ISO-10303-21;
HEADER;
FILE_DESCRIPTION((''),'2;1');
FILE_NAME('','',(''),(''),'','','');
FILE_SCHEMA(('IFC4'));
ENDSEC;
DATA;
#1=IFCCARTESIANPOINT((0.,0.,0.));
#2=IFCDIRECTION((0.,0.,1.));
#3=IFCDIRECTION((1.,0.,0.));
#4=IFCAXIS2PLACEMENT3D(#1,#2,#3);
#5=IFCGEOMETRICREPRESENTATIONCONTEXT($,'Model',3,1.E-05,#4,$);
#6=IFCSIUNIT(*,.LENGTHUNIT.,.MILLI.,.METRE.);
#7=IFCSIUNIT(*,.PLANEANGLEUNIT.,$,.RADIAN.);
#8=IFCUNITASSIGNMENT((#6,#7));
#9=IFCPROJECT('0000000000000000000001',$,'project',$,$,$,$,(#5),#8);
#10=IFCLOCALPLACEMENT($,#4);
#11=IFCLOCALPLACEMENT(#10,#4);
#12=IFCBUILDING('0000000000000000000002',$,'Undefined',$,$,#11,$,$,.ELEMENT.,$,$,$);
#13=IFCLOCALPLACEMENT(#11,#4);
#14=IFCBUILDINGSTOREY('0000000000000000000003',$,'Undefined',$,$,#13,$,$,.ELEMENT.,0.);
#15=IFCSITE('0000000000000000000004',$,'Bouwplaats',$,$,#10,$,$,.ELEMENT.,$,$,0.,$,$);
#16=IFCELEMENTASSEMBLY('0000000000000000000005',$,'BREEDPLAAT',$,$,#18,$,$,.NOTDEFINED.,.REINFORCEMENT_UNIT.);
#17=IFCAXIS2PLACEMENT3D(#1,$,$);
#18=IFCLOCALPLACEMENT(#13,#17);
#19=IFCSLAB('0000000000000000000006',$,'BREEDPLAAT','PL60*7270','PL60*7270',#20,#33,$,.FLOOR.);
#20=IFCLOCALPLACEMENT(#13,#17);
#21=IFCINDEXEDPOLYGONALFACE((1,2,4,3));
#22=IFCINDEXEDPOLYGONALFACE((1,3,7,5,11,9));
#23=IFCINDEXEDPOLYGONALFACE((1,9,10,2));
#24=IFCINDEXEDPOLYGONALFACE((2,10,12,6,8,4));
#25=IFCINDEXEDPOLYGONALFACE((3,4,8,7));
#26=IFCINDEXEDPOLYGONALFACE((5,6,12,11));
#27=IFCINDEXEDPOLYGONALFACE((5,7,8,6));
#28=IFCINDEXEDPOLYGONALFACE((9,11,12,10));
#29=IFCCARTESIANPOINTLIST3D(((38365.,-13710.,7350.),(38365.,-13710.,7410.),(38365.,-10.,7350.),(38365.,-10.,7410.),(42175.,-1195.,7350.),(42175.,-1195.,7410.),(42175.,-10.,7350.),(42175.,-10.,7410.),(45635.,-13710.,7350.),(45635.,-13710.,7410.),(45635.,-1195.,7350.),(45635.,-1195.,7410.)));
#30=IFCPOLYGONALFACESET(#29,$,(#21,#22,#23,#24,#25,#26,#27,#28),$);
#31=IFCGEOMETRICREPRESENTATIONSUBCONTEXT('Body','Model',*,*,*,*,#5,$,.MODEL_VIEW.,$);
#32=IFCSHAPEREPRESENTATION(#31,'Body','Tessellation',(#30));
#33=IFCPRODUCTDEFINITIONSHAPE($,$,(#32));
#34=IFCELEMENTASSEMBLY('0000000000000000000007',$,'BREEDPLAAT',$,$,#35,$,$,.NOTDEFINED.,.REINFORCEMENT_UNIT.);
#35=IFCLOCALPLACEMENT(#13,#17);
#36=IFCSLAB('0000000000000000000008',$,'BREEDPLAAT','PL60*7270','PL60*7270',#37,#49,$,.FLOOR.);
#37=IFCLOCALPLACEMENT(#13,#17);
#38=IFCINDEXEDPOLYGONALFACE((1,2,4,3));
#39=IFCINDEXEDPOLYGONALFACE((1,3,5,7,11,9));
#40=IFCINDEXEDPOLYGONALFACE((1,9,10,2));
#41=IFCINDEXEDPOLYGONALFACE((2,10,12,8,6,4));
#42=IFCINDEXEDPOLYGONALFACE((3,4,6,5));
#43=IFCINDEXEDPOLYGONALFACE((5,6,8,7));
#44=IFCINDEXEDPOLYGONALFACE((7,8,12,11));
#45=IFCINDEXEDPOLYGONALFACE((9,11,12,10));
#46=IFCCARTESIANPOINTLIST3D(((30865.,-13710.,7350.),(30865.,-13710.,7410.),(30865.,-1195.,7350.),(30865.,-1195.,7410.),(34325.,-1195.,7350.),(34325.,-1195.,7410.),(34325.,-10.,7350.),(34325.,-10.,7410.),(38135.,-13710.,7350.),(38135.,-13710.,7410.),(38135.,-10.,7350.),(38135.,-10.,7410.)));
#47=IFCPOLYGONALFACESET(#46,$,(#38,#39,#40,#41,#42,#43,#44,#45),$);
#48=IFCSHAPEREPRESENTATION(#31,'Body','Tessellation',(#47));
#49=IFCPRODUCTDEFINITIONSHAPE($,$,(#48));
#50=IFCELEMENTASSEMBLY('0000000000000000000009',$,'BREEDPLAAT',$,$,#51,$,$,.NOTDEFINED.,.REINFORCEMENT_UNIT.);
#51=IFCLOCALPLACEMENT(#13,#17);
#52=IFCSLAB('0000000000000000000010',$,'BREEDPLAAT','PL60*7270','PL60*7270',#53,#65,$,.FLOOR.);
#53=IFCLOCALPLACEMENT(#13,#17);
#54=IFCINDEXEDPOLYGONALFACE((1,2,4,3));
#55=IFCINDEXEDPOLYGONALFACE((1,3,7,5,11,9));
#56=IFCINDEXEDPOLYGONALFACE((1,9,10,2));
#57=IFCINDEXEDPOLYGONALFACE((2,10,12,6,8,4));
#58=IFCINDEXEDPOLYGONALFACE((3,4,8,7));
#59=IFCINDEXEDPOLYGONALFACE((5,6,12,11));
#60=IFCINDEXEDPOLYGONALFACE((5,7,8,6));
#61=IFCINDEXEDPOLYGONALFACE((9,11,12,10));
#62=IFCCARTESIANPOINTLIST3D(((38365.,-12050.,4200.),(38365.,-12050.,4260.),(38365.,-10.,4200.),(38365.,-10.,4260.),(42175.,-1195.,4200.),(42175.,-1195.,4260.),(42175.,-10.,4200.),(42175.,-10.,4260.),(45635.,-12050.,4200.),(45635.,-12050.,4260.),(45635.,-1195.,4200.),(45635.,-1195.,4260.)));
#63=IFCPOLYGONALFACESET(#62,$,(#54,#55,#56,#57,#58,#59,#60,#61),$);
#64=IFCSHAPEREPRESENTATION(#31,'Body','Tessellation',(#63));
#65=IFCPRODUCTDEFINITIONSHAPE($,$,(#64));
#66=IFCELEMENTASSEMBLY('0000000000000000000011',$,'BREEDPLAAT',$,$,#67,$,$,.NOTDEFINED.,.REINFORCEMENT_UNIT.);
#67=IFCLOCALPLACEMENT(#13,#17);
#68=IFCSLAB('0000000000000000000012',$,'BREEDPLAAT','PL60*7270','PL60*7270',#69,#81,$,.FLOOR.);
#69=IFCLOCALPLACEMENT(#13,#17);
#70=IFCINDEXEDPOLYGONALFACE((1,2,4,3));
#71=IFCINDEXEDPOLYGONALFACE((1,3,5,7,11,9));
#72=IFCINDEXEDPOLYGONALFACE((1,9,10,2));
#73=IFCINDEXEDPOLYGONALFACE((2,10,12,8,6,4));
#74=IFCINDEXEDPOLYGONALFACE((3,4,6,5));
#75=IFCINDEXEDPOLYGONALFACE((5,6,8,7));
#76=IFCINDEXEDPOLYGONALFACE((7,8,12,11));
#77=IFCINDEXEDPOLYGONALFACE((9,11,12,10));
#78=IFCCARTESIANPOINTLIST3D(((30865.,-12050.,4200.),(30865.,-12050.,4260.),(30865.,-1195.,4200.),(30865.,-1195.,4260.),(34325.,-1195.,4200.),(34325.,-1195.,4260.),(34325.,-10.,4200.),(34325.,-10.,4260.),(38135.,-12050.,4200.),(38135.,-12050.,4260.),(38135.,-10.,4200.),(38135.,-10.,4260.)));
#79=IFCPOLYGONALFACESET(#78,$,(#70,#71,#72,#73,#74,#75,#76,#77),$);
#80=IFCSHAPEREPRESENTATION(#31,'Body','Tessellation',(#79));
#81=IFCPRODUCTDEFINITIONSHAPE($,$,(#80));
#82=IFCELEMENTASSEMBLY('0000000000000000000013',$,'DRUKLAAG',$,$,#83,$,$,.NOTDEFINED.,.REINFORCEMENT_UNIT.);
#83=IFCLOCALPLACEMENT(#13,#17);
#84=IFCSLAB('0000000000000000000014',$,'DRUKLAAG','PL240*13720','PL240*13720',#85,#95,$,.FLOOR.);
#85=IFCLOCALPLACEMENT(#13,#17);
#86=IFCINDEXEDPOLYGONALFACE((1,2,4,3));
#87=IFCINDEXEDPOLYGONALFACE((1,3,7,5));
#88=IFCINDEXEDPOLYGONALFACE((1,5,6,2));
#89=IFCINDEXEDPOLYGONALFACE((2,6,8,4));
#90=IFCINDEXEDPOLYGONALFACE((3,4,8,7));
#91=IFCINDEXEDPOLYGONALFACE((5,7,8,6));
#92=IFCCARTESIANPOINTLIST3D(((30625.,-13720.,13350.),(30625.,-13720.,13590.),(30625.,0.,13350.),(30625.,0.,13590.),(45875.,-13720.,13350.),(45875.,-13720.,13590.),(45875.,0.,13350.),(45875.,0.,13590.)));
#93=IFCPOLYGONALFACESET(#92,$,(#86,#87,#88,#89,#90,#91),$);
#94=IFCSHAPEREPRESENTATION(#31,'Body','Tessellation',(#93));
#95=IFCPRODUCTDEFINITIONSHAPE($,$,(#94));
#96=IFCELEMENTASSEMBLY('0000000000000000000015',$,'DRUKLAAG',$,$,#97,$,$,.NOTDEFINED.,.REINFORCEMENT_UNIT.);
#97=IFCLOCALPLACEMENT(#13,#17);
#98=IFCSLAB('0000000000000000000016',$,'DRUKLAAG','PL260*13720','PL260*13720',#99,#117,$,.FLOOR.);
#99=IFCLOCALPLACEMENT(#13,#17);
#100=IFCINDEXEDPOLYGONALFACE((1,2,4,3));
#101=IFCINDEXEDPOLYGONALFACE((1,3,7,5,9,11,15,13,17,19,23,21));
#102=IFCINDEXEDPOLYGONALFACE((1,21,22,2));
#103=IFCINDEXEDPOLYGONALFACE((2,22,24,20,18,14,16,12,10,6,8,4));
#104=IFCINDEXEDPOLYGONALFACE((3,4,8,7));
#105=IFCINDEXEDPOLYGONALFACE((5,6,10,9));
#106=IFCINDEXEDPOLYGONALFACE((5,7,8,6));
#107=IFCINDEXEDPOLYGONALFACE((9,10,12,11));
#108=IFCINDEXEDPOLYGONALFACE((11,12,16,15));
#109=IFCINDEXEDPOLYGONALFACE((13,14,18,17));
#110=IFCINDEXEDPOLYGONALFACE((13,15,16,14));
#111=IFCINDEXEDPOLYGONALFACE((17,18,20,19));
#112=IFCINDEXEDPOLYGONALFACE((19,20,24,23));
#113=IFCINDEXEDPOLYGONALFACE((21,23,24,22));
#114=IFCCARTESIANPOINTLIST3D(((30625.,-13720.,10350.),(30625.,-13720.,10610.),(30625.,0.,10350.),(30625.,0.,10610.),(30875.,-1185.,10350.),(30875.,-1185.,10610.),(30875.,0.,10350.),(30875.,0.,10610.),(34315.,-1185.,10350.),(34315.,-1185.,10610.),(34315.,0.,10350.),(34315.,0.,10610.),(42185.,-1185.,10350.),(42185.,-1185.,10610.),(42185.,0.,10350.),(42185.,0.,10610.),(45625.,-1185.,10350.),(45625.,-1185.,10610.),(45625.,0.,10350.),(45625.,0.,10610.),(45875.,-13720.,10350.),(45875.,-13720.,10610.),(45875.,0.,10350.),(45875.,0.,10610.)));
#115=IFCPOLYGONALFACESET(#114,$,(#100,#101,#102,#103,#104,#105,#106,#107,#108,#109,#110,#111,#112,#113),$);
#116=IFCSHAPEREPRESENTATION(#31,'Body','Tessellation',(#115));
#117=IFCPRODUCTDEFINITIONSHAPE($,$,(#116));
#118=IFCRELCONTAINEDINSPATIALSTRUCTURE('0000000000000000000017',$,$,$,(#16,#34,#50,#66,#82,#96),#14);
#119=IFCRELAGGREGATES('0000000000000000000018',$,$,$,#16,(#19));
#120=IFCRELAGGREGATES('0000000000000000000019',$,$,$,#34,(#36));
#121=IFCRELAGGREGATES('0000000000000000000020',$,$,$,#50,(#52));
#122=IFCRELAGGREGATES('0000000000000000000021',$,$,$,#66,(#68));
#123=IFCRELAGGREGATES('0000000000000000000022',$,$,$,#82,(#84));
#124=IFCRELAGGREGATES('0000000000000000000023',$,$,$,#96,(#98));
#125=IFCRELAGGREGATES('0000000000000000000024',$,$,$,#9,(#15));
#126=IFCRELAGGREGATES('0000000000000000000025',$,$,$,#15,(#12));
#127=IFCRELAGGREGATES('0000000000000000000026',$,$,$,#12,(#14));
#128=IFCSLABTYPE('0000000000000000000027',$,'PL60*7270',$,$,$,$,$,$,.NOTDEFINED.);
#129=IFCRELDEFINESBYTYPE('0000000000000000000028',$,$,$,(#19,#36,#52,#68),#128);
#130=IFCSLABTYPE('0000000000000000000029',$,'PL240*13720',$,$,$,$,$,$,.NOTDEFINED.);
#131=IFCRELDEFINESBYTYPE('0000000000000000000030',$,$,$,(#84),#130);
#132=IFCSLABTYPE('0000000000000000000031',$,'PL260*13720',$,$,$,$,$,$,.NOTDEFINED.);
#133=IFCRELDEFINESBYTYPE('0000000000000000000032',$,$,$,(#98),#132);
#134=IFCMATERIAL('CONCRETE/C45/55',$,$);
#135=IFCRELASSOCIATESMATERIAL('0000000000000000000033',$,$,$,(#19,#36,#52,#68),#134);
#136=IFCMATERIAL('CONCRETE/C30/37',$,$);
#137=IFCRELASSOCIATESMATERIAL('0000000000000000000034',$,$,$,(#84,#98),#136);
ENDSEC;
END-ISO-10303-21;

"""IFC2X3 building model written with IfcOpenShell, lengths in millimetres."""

from ifc_helpers import new_model, si_unit, frame, origin_with_axes, place, context, subcontext, project, spatial, polyline, outline, extrude, boolean, material, type_object, element, aggregate, save


model = new_model("IFC2X3")

# Units and contexts
model_context = context("Model", 3, precision=1e-05, world=origin_with_axes())
body_context = subcontext(model_context, "Body", "Model", "MODEL_VIEW")
ifc_project = project(units=[si_unit("LENGTHUNIT", "METRE", prefix="MILLI"), si_unit("PLANEANGLEUNIT", "RADIAN")], contexts=[model_context])

# Site, building, storey
site_placement = place(None, origin_with_axes())
site = spatial("IfcSite", under=ifc_project, at=site_placement, Name="Bouwplaats", CompositionType="ELEMENT", RefElevation=0.0)
building_placement = place(site_placement, origin_with_axes())
building = spatial("IfcBuilding", under=site, at=building_placement, Name="Undefined", CompositionType="ELEMENT")
storey_placement = place(building_placement, origin_with_axes())
storey = spatial("IfcBuildingStorey", under=building, at=storey_placement, Name="Undefined", CompositionType="ELEMENT", Elevation=0.0)

# Element assemblies, slabs
ifc_material_1 = material(Name="CONCRETE/C45/55")
slab_type_1 = type_object("IfcSlabType", Name="PL60*7270", PredefinedType="NOTDEFINED")
assembly_1_placement = place(storey_placement, origin_with_axes())
assembly_1 = element("IfcElementAssembly", 1, at=assembly_1_placement, inside=storey, Name="BREEDPLAAT", AssemblyPlace="NOTDEFINED", PredefinedType="REINFORCEMENT_UNIT")
slab_1_placement = place(assembly_1_placement, frame((42175.0, -10.0, 7380.0), z_axis=(0.0, 0.0, 1.0), x_axis=(-1.0, 0.0, 0.0)))
slab_1 = element("IfcSlab", 2, at=slab_1_placement, type_object=slab_type_1, material=ifc_material_1, Name="BREEDPLAAT", Description="PL60*7270", ObjectType="PL60*7270", PredefinedType="FLOOR", context=body_context, shape_type="SweptSolid", body=[
    extrude(outline(polyline([(0.0, 0.0), (3810.0, 0.0), (3810.0, 13700.0), (-3460.0, 13700.0), (-3460.0, 1185.0), (0.0, 1185.0), (0.0, 0.0)])), frame((0.0, 0.0, -30.0), z_axis=(0.0, 0.0, 1.0), x_axis=(1.0, 0.0, 0.0)), (0.0, 0.0, 1.0), 60.0),
])
aggregate(assembly_1, [slab_1])
assembly_2_placement = place(storey_placement, origin_with_axes())
assembly_2 = element("IfcElementAssembly", 3, at=assembly_2_placement, inside=storey, Name="BREEDPLAAT", AssemblyPlace="NOTDEFINED", PredefinedType="REINFORCEMENT_UNIT")
slab_2_placement = place(assembly_2_placement, frame((34325.0, -1195.0, 7380.0), z_axis=(0.0, 0.0, 1.0), x_axis=(-1.0, 0.0, 0.0)))
slab_2 = element("IfcSlab", 4, at=slab_2_placement, type_object=slab_type_1, material=ifc_material_1, Name="BREEDPLAAT", Description="PL60*7270", ObjectType="PL60*7270", PredefinedType="FLOOR", context=body_context, shape_type="SweptSolid", body=[
    extrude(outline(polyline([(0.0, 0.0), (3460.0, 0.0), (3460.0, 12515.0), (-3810.0, 12515.0), (-3810.0, -1185.0), (0.0, -1185.0), (0.0, 0.0)])), frame((0.0, 0.0, -30.0), z_axis=(0.0, 0.0, 1.0), x_axis=(1.0, 0.0, 0.0)), (0.0, 0.0, 1.0), 60.0),
])
aggregate(assembly_2, [slab_2])
assembly_3_placement = place(storey_placement, origin_with_axes())
assembly_3 = element("IfcElementAssembly", 5, at=assembly_3_placement, inside=storey, Name="BREEDPLAAT", AssemblyPlace="NOTDEFINED", PredefinedType="REINFORCEMENT_UNIT")
slab_3_placement = place(assembly_3_placement, frame((42175.0, -10.0, 4230.0), z_axis=(0.0, 0.0, 1.0), x_axis=(-1.0, 0.0, 0.0)))
slab_3 = element("IfcSlab", 6, at=slab_3_placement, type_object=slab_type_1, material=ifc_material_1, Name="BREEDPLAAT", Description="PL60*7270", ObjectType="PL60*7270", PredefinedType="FLOOR", context=body_context, shape_type="SweptSolid", body=[
    extrude(outline(polyline([(0.0, 0.0), (3810.0, 0.0), (3810.0, 12040.0), (-3460.0, 12040.0), (-3460.0, 1185.0), (0.0, 1185.0), (0.0, 0.0)])), frame((0.0, 0.0, -30.0), z_axis=(0.0, 0.0, 1.0), x_axis=(1.0, 0.0, 0.0)), (0.0, 0.0, 1.0), 60.0),
])
aggregate(assembly_3, [slab_3])
assembly_4_placement = place(storey_placement, origin_with_axes())
assembly_4 = element("IfcElementAssembly", 7, at=assembly_4_placement, inside=storey, Name="BREEDPLAAT", AssemblyPlace="NOTDEFINED", PredefinedType="REINFORCEMENT_UNIT")
slab_4_placement = place(assembly_4_placement, frame((34325.0, -1195.0, 4230.0), z_axis=(0.0, 0.0, 1.0), x_axis=(-1.0, 0.0, 0.0)))
slab_4 = element("IfcSlab", 8, at=slab_4_placement, type_object=slab_type_1, material=ifc_material_1, Name="BREEDPLAAT", Description="PL60*7270", ObjectType="PL60*7270", PredefinedType="FLOOR", context=body_context, shape_type="SweptSolid", body=[
    extrude(outline(polyline([(0.0, 0.0), (3460.0, 0.0), (3460.0, 10855.0), (-3810.0, 10855.0), (-3810.0, -1185.0), (0.0, -1185.0), (0.0, 0.0)])), frame((0.0, 0.0, -30.0), z_axis=(0.0, 0.0, 1.0), x_axis=(1.0, 0.0, 0.0)), (0.0, 0.0, 1.0), 60.0),
])
aggregate(assembly_4, [slab_4])
assembly_5_placement = place(storey_placement, origin_with_axes())
assembly_5 = element("IfcElementAssembly", 9, at=assembly_5_placement, inside=storey, Name="DRUKLAAG", AssemblyPlace="NOTDEFINED", PredefinedType="REINFORCEMENT_UNIT")
ifc_material_2 = material(Name="CONCRETE/C30/37")
slab_type_2 = type_object("IfcSlabType", Name="PL240*13720", PredefinedType="NOTDEFINED")
slab_5_placement = place(assembly_5_placement, frame((45875.0, 0.0, 13470.0), z_axis=(0.0, 0.0, 1.0), x_axis=(-1.0, 0.0, 0.0)))
slab_5 = element("IfcSlab", 10, at=slab_5_placement, type_object=slab_type_2, material=ifc_material_2, Name="DRUKLAAG", Description="PL240*13720", ObjectType="PL240*13720", PredefinedType="FLOOR", context=body_context, shape_type="SweptSolid", body=[
    extrude(outline(polyline([(0.0, 0.0), (15250.0, 0.0), (15250.0, 13720.0), (0.0, 13720.0), (0.0, 0.0)])), frame((0.0, 0.0, -120.0), z_axis=(0.0, 0.0, 1.0), x_axis=(1.0, 0.0, 0.0)), (0.0, 0.0, 1.0), 240.0),
])
aggregate(assembly_5, [slab_5])
assembly_6_placement = place(storey_placement, origin_with_axes())
assembly_6 = element("IfcElementAssembly", 11, at=assembly_6_placement, inside=storey, Name="DRUKLAAG", AssemblyPlace="NOTDEFINED", PredefinedType="REINFORCEMENT_UNIT")
slab_type_3 = type_object("IfcSlabType", Name="PL260*13720", PredefinedType="NOTDEFINED")
slab_6_placement = place(assembly_6_placement, frame((45875.0, 0.0, 10480.0), z_axis=(0.0, 0.0, 1.0), x_axis=(-1.0, 0.0, 0.0)))
slab_6 = element("IfcSlab", 12, at=slab_6_placement, type_object=slab_type_3, material=ifc_material_2, Name="DRUKLAAG", Description="PL260*13720", ObjectType="PL260*13720", PredefinedType="FLOOR", context=body_context, shape_type="CSG", body=[
    boolean("DIFFERENCE", boolean("DIFFERENCE", extrude(outline(polyline([(0.0, 0.0), (15250.0, 0.0), (15250.0, 13720.0), (0.0, 13720.0), (0.0, 0.0)])), frame((0.0, 0.0, -130.0), z_axis=(0.0, 0.0, 1.0), x_axis=(1.0, 0.0, 0.0)), (0.0, 0.0, 1.0), 260.0), extrude(outline(polyline([(0.0, 0.0), (1185.0, 0.0), (1185.0, 3440.0), (0.0, 3440.0), (0.0, 0.0)])), frame((15000.0, 0.0, -140.0), z_axis=(0.0, 0.0, 1.0), x_axis=(0.0, 1.0, 0.0)), (0.0, 0.0, 1.0), 280.0)), extrude(outline(polyline([(0.0, 0.0), (1185.0, 0.0), (1185.0, 3440.0), (0.0, 3440.0), (0.0, 0.0)])), frame((3690.0, 0.0, -140.0), z_axis=(0.0, 0.0, 1.0), x_axis=(0.0, 1.0, 0.0)), (0.0, 0.0, 1.0), 280.0)),
])
aggregate(assembly_6, [slab_6])

save(model, "model.ifc")
